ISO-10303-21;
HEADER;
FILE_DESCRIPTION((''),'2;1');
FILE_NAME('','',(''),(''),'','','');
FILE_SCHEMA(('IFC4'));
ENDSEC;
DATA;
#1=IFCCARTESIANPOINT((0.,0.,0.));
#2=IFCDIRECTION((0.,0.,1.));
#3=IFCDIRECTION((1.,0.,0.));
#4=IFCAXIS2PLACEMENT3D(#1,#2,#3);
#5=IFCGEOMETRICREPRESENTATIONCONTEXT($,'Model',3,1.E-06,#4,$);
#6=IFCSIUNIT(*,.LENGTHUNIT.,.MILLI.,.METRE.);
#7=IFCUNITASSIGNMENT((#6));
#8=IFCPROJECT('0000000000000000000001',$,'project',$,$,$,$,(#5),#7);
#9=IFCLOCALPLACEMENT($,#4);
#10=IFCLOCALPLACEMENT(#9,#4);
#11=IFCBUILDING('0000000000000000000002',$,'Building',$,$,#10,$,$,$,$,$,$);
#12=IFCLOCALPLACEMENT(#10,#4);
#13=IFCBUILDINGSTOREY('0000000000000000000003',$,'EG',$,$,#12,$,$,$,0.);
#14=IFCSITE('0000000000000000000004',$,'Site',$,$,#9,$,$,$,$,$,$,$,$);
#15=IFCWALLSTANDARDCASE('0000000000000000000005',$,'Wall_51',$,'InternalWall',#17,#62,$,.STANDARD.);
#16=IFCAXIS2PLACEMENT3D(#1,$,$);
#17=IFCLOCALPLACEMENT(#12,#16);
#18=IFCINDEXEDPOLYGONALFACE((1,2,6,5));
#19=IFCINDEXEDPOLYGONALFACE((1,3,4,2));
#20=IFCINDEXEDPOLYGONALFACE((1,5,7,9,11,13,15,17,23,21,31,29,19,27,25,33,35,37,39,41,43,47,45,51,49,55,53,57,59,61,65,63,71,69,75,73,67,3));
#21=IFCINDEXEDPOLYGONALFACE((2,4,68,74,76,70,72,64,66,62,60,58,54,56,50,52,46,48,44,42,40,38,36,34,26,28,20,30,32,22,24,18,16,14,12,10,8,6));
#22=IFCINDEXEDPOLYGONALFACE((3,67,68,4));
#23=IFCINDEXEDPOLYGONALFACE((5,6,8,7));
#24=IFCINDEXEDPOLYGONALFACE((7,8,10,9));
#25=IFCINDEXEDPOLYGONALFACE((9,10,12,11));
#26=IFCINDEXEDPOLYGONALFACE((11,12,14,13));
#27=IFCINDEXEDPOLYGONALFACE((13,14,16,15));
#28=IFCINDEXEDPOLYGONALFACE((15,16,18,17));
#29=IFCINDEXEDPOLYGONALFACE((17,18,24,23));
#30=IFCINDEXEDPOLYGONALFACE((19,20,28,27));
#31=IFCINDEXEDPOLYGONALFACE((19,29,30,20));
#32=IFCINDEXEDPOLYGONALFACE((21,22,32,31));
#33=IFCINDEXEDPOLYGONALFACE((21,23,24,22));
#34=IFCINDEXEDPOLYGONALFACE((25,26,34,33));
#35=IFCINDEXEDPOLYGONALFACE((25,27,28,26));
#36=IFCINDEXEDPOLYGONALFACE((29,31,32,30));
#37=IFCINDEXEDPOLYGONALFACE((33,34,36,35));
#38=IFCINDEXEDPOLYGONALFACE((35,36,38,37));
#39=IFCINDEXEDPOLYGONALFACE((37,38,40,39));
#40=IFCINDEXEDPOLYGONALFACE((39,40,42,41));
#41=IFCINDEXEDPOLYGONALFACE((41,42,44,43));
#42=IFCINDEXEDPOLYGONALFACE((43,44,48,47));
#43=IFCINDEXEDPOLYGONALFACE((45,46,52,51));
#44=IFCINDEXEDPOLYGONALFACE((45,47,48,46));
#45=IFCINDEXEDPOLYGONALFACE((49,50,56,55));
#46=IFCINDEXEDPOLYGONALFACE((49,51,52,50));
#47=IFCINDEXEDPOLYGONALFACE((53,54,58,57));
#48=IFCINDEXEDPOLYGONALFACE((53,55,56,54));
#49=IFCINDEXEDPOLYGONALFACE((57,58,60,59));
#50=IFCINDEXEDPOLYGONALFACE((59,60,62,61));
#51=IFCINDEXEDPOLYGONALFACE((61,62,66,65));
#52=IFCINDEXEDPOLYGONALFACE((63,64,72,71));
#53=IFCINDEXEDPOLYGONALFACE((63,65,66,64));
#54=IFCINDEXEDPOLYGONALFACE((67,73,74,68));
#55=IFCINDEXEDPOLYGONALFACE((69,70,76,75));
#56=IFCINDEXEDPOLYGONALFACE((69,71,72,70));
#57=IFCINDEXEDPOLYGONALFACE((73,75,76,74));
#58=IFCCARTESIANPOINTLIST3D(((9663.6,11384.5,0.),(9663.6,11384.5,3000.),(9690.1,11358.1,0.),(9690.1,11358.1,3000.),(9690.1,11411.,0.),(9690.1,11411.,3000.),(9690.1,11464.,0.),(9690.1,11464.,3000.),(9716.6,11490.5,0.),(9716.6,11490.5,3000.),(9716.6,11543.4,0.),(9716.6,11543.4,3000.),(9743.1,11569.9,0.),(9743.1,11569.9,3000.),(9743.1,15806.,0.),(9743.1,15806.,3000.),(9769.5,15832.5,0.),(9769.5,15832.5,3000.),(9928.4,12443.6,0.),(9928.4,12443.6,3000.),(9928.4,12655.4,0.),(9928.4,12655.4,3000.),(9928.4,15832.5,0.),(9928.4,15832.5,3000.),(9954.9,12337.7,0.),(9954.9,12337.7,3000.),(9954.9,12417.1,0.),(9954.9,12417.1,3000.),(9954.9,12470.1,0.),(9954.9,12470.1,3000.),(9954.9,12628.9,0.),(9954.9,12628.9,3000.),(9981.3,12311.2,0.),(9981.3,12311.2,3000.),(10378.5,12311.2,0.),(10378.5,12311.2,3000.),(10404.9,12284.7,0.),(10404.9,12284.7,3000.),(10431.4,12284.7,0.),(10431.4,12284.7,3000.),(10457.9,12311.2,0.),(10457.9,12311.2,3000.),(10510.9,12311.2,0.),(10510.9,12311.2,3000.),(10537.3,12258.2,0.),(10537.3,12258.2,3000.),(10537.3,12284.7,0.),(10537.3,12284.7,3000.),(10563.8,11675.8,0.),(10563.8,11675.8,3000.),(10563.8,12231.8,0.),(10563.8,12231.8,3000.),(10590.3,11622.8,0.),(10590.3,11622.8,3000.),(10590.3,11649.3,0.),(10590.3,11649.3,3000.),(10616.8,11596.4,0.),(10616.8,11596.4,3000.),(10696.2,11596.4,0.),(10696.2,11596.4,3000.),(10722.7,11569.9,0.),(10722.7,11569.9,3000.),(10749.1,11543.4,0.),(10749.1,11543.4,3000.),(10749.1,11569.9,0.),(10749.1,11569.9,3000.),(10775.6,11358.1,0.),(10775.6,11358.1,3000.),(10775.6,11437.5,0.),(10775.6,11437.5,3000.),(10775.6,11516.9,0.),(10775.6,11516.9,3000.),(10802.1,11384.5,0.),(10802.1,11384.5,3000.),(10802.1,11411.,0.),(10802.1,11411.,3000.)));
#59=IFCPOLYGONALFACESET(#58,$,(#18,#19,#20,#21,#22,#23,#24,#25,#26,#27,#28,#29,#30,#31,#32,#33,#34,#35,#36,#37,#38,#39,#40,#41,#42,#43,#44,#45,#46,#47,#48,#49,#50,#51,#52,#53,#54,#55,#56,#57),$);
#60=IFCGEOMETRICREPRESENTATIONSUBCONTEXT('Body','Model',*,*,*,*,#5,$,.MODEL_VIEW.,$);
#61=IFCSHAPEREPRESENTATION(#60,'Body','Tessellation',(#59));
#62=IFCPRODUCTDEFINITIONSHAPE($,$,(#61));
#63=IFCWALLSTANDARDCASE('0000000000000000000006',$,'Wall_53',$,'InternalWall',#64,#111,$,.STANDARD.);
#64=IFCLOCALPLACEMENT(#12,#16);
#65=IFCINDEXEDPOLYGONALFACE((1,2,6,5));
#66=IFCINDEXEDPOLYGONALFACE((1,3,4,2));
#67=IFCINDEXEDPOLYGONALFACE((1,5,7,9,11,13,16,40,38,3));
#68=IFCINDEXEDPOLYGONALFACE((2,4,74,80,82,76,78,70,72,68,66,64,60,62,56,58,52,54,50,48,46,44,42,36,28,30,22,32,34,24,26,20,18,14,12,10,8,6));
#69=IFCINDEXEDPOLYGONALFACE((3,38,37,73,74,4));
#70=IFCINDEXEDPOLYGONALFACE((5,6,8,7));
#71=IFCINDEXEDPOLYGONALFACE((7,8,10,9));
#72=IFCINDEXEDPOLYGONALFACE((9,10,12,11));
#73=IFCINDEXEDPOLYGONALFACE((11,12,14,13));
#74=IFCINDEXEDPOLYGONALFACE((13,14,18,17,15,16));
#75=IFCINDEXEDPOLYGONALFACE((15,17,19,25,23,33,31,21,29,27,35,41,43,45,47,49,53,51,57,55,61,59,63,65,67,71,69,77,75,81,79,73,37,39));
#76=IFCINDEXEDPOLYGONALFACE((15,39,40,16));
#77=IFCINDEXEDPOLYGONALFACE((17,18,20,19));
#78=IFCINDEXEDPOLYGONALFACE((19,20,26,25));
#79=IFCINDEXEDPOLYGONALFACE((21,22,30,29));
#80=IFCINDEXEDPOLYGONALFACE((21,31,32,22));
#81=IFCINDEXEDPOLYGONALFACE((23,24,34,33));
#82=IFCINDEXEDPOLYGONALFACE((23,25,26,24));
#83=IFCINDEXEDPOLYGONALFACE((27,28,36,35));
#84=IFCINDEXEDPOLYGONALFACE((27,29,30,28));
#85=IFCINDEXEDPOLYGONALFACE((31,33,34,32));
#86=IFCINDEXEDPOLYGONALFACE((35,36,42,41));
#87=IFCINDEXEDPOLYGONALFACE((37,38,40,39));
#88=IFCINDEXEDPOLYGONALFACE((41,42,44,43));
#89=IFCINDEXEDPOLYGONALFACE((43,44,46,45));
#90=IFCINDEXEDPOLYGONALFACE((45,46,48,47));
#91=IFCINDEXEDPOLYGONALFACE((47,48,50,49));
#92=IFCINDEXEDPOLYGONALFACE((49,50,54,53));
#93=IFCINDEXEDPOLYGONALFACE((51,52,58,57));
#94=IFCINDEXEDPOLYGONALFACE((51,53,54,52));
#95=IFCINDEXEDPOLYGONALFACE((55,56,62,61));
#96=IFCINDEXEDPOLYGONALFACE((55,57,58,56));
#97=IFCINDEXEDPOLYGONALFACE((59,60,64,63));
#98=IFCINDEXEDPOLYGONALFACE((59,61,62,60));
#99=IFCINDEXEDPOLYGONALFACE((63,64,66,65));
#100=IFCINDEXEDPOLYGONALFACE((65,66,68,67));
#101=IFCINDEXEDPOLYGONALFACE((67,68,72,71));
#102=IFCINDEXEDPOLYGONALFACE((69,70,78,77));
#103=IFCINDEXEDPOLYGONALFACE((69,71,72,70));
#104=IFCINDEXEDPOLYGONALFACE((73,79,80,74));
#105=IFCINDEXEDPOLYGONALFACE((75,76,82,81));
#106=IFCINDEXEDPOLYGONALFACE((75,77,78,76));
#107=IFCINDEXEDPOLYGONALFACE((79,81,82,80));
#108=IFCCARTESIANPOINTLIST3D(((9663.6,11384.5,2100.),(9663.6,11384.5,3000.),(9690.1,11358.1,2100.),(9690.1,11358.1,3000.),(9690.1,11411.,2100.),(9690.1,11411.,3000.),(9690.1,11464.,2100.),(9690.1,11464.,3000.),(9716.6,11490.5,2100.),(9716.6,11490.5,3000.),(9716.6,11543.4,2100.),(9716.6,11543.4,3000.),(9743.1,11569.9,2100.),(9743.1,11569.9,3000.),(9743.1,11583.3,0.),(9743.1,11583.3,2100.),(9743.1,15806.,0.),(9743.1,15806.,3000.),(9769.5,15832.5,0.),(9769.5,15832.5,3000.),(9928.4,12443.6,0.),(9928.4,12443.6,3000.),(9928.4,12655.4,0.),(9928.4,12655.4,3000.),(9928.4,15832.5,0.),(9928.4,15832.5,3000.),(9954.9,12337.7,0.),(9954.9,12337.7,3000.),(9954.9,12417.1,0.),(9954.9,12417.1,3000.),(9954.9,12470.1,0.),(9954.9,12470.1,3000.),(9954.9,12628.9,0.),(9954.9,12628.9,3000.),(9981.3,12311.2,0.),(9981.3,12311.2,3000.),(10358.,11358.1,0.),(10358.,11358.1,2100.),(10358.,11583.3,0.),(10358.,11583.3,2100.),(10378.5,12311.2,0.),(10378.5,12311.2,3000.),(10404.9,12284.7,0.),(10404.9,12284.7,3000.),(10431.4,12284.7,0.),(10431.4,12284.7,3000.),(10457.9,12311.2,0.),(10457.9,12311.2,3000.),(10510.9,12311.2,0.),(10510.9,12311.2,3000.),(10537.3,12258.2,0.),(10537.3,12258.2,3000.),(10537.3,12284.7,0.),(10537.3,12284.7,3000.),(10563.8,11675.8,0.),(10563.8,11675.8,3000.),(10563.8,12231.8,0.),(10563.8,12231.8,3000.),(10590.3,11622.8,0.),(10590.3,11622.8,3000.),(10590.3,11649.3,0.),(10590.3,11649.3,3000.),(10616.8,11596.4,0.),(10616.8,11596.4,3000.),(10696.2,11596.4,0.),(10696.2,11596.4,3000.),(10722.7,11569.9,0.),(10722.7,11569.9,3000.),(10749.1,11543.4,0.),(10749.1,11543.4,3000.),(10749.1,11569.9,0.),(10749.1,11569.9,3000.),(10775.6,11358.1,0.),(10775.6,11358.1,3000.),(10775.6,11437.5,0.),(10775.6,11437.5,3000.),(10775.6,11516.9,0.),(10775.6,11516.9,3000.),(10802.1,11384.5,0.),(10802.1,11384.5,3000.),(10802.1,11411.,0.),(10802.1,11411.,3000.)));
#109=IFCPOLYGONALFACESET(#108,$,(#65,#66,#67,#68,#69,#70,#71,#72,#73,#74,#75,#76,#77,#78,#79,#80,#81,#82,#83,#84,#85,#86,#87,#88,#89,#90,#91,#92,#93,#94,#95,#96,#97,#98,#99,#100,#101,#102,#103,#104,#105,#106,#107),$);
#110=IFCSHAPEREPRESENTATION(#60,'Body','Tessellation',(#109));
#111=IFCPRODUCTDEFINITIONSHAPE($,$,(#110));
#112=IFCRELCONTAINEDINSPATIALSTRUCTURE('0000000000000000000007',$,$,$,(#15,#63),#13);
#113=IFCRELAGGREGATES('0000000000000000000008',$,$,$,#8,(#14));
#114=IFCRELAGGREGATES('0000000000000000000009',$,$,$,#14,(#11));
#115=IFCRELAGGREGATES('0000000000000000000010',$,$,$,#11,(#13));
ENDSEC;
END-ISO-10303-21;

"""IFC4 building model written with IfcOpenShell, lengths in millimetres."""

from ifc_helpers import new_model, si_unit, frame, origin_with_axes, place, context, subcontext, project, spatial, polyline, rectangle, outline, extrude, element, save


model = new_model("IFC4")

# Units and contexts
model_context = context("Model", 3, precision=1e-06, world=origin_with_axes())
body_context = subcontext(model_context, "Body", "Model", "MODEL_VIEW")
ifc_project = project(units=[si_unit("LENGTHUNIT", "METRE", prefix="MILLI")], contexts=[model_context])

# Site, building, storey
site_placement = place(None, origin_with_axes())
site = spatial("IfcSite", under=ifc_project, at=site_placement, Name="Site")
building_placement = place(site_placement, origin_with_axes())
building = spatial("IfcBuilding", under=site, at=building_placement, Name="Building")
storey_placement = place(building_placement, origin_with_axes())
storey = spatial("IfcBuildingStorey", under=building, at=storey_placement, Name="EG", Elevation=0.0)

# Wall
for number, where, z_axis, x_axis, name in (
    (1, (0.0, 0.0, 0.0), (0.0, 0.0, 1.0), (1.0, 0.0, 0.0), "Wall_51"),
):
    element("IfcWallStandardCase", number, at=place(storey_placement, frame(where, z_axis=z_axis, x_axis=x_axis)), inside=storey, Name=name, ObjectType="InternalWall", PredefinedType="STANDARD", context=body_context, shape_type="SweptSolid", body=[
        extrude(outline(polyline([(9690.1, 11358.1, 0.0), (9663.6, 11384.5, 0.0), (9690.1, 11411.0, 0.0), (9690.1, 11464.0, 0.0), (9716.6, 11490.5, 0.0), (9716.6, 11543.4, 0.0), (9743.1, 11569.9, 0.0), (9743.1, 15806.0, 0.0), (9769.5, 15832.5, 0.0), (9928.4, 15832.5, 0.0), (9928.4, 12655.4, 0.0), (9954.9, 12628.9, 0.0), (9954.9, 12470.1, 0.0), (9928.4, 12443.6, 0.0), (9954.9, 12417.1, 0.0), (9954.9, 12337.7, 0.0), (9981.3, 12311.2, 0.0), (10378.5, 12311.2, 0.0), (10404.9, 12284.7, 0.0), (10431.4, 12284.7, 0.0), (10457.9, 12311.2, 0.0), (10510.9, 12311.2, 0.0), (10537.3, 12284.7, 0.0), (10537.3, 12258.2, 0.0), (10563.8, 12231.8, 0.0), (10563.8, 11675.8, 0.0), (10590.3, 11649.3, 0.0), (10590.3, 11622.8, 0.0), (10616.8, 11596.4, 0.0), (10696.2, 11596.4, 0.0), (10722.7, 11569.9, 0.0), (10749.1, 11569.9, 0.0), (10749.1, 11543.4, 0.0), (10775.6, 11516.9, 0.0), (10775.6, 11437.5, 0.0), (10802.1, 11411.0, 0.0), (10802.1, 11384.5, 0.0), (10775.6, 11358.1, 0.0), (9690.1, 11358.1, 0.0)])), origin_with_axes(), (0.0, 0.0, 1.0), 3000.0),
    ])

# Wall, opening
wall_1_placement = place(storey_placement, origin_with_axes())
wall_1 = element("IfcWallStandardCase", 2, at=wall_1_placement, inside=storey, Name="Wall_53", ObjectType="InternalWall", PredefinedType="STANDARD", context=body_context, shape_type="SweptSolid", body=[
    extrude(outline(polyline([(9690.1, 11358.1, 0.0), (9663.6, 11384.5, 0.0), (9690.1, 11411.0, 0.0), (9690.1, 11464.0, 0.0), (9716.6, 11490.5, 0.0), (9716.6, 11543.4, 0.0), (9743.1, 11569.9, 0.0), (9743.1, 15806.0, 0.0), (9769.5, 15832.5, 0.0), (9928.4, 15832.5, 0.0), (9928.4, 12655.4, 0.0), (9954.9, 12628.9, 0.0), (9954.9, 12470.1, 0.0), (9928.4, 12443.6, 0.0), (9954.9, 12417.1, 0.0), (9954.9, 12337.7, 0.0), (9981.3, 12311.2, 0.0), (10378.5, 12311.2, 0.0), (10404.9, 12284.7, 0.0), (10431.4, 12284.7, 0.0), (10457.9, 12311.2, 0.0), (10510.9, 12311.2, 0.0), (10537.3, 12284.7, 0.0), (10537.3, 12258.2, 0.0), (10563.8, 12231.8, 0.0), (10563.8, 11675.8, 0.0), (10590.3, 11649.3, 0.0), (10590.3, 11622.8, 0.0), (10616.8, 11596.4, 0.0), (10696.2, 11596.4, 0.0), (10722.7, 11569.9, 0.0), (10749.1, 11569.9, 0.0), (10749.1, 11543.4, 0.0), (10775.6, 11516.9, 0.0), (10775.6, 11437.5, 0.0), (10802.1, 11411.0, 0.0), (10802.1, 11384.5, 0.0), (10775.6, 11358.1, 0.0), (9690.1, 11358.1, 0.0)])), origin_with_axes(), (0.0, 0.0, 1.0), 3000.0),
])
opening_1_placement = place(wall_1_placement, origin_with_axes())
element("IfcOpeningElement", 3, at=opening_1_placement, inside=storey, cuts=wall_1, context=body_context, shape_type="SweptSolid", body=[
    extrude(rectangle(XDim=1342.1, YDim=400.0), frame((9687.0, 11383.3, 0.0), z_axis=(0.0, 0.0, 1.0), x_axis=(1.0, 0.0, 0.0)), (0.0, 0.0, 1.0), 2100.0),
])

save(model, "model.ifc")
